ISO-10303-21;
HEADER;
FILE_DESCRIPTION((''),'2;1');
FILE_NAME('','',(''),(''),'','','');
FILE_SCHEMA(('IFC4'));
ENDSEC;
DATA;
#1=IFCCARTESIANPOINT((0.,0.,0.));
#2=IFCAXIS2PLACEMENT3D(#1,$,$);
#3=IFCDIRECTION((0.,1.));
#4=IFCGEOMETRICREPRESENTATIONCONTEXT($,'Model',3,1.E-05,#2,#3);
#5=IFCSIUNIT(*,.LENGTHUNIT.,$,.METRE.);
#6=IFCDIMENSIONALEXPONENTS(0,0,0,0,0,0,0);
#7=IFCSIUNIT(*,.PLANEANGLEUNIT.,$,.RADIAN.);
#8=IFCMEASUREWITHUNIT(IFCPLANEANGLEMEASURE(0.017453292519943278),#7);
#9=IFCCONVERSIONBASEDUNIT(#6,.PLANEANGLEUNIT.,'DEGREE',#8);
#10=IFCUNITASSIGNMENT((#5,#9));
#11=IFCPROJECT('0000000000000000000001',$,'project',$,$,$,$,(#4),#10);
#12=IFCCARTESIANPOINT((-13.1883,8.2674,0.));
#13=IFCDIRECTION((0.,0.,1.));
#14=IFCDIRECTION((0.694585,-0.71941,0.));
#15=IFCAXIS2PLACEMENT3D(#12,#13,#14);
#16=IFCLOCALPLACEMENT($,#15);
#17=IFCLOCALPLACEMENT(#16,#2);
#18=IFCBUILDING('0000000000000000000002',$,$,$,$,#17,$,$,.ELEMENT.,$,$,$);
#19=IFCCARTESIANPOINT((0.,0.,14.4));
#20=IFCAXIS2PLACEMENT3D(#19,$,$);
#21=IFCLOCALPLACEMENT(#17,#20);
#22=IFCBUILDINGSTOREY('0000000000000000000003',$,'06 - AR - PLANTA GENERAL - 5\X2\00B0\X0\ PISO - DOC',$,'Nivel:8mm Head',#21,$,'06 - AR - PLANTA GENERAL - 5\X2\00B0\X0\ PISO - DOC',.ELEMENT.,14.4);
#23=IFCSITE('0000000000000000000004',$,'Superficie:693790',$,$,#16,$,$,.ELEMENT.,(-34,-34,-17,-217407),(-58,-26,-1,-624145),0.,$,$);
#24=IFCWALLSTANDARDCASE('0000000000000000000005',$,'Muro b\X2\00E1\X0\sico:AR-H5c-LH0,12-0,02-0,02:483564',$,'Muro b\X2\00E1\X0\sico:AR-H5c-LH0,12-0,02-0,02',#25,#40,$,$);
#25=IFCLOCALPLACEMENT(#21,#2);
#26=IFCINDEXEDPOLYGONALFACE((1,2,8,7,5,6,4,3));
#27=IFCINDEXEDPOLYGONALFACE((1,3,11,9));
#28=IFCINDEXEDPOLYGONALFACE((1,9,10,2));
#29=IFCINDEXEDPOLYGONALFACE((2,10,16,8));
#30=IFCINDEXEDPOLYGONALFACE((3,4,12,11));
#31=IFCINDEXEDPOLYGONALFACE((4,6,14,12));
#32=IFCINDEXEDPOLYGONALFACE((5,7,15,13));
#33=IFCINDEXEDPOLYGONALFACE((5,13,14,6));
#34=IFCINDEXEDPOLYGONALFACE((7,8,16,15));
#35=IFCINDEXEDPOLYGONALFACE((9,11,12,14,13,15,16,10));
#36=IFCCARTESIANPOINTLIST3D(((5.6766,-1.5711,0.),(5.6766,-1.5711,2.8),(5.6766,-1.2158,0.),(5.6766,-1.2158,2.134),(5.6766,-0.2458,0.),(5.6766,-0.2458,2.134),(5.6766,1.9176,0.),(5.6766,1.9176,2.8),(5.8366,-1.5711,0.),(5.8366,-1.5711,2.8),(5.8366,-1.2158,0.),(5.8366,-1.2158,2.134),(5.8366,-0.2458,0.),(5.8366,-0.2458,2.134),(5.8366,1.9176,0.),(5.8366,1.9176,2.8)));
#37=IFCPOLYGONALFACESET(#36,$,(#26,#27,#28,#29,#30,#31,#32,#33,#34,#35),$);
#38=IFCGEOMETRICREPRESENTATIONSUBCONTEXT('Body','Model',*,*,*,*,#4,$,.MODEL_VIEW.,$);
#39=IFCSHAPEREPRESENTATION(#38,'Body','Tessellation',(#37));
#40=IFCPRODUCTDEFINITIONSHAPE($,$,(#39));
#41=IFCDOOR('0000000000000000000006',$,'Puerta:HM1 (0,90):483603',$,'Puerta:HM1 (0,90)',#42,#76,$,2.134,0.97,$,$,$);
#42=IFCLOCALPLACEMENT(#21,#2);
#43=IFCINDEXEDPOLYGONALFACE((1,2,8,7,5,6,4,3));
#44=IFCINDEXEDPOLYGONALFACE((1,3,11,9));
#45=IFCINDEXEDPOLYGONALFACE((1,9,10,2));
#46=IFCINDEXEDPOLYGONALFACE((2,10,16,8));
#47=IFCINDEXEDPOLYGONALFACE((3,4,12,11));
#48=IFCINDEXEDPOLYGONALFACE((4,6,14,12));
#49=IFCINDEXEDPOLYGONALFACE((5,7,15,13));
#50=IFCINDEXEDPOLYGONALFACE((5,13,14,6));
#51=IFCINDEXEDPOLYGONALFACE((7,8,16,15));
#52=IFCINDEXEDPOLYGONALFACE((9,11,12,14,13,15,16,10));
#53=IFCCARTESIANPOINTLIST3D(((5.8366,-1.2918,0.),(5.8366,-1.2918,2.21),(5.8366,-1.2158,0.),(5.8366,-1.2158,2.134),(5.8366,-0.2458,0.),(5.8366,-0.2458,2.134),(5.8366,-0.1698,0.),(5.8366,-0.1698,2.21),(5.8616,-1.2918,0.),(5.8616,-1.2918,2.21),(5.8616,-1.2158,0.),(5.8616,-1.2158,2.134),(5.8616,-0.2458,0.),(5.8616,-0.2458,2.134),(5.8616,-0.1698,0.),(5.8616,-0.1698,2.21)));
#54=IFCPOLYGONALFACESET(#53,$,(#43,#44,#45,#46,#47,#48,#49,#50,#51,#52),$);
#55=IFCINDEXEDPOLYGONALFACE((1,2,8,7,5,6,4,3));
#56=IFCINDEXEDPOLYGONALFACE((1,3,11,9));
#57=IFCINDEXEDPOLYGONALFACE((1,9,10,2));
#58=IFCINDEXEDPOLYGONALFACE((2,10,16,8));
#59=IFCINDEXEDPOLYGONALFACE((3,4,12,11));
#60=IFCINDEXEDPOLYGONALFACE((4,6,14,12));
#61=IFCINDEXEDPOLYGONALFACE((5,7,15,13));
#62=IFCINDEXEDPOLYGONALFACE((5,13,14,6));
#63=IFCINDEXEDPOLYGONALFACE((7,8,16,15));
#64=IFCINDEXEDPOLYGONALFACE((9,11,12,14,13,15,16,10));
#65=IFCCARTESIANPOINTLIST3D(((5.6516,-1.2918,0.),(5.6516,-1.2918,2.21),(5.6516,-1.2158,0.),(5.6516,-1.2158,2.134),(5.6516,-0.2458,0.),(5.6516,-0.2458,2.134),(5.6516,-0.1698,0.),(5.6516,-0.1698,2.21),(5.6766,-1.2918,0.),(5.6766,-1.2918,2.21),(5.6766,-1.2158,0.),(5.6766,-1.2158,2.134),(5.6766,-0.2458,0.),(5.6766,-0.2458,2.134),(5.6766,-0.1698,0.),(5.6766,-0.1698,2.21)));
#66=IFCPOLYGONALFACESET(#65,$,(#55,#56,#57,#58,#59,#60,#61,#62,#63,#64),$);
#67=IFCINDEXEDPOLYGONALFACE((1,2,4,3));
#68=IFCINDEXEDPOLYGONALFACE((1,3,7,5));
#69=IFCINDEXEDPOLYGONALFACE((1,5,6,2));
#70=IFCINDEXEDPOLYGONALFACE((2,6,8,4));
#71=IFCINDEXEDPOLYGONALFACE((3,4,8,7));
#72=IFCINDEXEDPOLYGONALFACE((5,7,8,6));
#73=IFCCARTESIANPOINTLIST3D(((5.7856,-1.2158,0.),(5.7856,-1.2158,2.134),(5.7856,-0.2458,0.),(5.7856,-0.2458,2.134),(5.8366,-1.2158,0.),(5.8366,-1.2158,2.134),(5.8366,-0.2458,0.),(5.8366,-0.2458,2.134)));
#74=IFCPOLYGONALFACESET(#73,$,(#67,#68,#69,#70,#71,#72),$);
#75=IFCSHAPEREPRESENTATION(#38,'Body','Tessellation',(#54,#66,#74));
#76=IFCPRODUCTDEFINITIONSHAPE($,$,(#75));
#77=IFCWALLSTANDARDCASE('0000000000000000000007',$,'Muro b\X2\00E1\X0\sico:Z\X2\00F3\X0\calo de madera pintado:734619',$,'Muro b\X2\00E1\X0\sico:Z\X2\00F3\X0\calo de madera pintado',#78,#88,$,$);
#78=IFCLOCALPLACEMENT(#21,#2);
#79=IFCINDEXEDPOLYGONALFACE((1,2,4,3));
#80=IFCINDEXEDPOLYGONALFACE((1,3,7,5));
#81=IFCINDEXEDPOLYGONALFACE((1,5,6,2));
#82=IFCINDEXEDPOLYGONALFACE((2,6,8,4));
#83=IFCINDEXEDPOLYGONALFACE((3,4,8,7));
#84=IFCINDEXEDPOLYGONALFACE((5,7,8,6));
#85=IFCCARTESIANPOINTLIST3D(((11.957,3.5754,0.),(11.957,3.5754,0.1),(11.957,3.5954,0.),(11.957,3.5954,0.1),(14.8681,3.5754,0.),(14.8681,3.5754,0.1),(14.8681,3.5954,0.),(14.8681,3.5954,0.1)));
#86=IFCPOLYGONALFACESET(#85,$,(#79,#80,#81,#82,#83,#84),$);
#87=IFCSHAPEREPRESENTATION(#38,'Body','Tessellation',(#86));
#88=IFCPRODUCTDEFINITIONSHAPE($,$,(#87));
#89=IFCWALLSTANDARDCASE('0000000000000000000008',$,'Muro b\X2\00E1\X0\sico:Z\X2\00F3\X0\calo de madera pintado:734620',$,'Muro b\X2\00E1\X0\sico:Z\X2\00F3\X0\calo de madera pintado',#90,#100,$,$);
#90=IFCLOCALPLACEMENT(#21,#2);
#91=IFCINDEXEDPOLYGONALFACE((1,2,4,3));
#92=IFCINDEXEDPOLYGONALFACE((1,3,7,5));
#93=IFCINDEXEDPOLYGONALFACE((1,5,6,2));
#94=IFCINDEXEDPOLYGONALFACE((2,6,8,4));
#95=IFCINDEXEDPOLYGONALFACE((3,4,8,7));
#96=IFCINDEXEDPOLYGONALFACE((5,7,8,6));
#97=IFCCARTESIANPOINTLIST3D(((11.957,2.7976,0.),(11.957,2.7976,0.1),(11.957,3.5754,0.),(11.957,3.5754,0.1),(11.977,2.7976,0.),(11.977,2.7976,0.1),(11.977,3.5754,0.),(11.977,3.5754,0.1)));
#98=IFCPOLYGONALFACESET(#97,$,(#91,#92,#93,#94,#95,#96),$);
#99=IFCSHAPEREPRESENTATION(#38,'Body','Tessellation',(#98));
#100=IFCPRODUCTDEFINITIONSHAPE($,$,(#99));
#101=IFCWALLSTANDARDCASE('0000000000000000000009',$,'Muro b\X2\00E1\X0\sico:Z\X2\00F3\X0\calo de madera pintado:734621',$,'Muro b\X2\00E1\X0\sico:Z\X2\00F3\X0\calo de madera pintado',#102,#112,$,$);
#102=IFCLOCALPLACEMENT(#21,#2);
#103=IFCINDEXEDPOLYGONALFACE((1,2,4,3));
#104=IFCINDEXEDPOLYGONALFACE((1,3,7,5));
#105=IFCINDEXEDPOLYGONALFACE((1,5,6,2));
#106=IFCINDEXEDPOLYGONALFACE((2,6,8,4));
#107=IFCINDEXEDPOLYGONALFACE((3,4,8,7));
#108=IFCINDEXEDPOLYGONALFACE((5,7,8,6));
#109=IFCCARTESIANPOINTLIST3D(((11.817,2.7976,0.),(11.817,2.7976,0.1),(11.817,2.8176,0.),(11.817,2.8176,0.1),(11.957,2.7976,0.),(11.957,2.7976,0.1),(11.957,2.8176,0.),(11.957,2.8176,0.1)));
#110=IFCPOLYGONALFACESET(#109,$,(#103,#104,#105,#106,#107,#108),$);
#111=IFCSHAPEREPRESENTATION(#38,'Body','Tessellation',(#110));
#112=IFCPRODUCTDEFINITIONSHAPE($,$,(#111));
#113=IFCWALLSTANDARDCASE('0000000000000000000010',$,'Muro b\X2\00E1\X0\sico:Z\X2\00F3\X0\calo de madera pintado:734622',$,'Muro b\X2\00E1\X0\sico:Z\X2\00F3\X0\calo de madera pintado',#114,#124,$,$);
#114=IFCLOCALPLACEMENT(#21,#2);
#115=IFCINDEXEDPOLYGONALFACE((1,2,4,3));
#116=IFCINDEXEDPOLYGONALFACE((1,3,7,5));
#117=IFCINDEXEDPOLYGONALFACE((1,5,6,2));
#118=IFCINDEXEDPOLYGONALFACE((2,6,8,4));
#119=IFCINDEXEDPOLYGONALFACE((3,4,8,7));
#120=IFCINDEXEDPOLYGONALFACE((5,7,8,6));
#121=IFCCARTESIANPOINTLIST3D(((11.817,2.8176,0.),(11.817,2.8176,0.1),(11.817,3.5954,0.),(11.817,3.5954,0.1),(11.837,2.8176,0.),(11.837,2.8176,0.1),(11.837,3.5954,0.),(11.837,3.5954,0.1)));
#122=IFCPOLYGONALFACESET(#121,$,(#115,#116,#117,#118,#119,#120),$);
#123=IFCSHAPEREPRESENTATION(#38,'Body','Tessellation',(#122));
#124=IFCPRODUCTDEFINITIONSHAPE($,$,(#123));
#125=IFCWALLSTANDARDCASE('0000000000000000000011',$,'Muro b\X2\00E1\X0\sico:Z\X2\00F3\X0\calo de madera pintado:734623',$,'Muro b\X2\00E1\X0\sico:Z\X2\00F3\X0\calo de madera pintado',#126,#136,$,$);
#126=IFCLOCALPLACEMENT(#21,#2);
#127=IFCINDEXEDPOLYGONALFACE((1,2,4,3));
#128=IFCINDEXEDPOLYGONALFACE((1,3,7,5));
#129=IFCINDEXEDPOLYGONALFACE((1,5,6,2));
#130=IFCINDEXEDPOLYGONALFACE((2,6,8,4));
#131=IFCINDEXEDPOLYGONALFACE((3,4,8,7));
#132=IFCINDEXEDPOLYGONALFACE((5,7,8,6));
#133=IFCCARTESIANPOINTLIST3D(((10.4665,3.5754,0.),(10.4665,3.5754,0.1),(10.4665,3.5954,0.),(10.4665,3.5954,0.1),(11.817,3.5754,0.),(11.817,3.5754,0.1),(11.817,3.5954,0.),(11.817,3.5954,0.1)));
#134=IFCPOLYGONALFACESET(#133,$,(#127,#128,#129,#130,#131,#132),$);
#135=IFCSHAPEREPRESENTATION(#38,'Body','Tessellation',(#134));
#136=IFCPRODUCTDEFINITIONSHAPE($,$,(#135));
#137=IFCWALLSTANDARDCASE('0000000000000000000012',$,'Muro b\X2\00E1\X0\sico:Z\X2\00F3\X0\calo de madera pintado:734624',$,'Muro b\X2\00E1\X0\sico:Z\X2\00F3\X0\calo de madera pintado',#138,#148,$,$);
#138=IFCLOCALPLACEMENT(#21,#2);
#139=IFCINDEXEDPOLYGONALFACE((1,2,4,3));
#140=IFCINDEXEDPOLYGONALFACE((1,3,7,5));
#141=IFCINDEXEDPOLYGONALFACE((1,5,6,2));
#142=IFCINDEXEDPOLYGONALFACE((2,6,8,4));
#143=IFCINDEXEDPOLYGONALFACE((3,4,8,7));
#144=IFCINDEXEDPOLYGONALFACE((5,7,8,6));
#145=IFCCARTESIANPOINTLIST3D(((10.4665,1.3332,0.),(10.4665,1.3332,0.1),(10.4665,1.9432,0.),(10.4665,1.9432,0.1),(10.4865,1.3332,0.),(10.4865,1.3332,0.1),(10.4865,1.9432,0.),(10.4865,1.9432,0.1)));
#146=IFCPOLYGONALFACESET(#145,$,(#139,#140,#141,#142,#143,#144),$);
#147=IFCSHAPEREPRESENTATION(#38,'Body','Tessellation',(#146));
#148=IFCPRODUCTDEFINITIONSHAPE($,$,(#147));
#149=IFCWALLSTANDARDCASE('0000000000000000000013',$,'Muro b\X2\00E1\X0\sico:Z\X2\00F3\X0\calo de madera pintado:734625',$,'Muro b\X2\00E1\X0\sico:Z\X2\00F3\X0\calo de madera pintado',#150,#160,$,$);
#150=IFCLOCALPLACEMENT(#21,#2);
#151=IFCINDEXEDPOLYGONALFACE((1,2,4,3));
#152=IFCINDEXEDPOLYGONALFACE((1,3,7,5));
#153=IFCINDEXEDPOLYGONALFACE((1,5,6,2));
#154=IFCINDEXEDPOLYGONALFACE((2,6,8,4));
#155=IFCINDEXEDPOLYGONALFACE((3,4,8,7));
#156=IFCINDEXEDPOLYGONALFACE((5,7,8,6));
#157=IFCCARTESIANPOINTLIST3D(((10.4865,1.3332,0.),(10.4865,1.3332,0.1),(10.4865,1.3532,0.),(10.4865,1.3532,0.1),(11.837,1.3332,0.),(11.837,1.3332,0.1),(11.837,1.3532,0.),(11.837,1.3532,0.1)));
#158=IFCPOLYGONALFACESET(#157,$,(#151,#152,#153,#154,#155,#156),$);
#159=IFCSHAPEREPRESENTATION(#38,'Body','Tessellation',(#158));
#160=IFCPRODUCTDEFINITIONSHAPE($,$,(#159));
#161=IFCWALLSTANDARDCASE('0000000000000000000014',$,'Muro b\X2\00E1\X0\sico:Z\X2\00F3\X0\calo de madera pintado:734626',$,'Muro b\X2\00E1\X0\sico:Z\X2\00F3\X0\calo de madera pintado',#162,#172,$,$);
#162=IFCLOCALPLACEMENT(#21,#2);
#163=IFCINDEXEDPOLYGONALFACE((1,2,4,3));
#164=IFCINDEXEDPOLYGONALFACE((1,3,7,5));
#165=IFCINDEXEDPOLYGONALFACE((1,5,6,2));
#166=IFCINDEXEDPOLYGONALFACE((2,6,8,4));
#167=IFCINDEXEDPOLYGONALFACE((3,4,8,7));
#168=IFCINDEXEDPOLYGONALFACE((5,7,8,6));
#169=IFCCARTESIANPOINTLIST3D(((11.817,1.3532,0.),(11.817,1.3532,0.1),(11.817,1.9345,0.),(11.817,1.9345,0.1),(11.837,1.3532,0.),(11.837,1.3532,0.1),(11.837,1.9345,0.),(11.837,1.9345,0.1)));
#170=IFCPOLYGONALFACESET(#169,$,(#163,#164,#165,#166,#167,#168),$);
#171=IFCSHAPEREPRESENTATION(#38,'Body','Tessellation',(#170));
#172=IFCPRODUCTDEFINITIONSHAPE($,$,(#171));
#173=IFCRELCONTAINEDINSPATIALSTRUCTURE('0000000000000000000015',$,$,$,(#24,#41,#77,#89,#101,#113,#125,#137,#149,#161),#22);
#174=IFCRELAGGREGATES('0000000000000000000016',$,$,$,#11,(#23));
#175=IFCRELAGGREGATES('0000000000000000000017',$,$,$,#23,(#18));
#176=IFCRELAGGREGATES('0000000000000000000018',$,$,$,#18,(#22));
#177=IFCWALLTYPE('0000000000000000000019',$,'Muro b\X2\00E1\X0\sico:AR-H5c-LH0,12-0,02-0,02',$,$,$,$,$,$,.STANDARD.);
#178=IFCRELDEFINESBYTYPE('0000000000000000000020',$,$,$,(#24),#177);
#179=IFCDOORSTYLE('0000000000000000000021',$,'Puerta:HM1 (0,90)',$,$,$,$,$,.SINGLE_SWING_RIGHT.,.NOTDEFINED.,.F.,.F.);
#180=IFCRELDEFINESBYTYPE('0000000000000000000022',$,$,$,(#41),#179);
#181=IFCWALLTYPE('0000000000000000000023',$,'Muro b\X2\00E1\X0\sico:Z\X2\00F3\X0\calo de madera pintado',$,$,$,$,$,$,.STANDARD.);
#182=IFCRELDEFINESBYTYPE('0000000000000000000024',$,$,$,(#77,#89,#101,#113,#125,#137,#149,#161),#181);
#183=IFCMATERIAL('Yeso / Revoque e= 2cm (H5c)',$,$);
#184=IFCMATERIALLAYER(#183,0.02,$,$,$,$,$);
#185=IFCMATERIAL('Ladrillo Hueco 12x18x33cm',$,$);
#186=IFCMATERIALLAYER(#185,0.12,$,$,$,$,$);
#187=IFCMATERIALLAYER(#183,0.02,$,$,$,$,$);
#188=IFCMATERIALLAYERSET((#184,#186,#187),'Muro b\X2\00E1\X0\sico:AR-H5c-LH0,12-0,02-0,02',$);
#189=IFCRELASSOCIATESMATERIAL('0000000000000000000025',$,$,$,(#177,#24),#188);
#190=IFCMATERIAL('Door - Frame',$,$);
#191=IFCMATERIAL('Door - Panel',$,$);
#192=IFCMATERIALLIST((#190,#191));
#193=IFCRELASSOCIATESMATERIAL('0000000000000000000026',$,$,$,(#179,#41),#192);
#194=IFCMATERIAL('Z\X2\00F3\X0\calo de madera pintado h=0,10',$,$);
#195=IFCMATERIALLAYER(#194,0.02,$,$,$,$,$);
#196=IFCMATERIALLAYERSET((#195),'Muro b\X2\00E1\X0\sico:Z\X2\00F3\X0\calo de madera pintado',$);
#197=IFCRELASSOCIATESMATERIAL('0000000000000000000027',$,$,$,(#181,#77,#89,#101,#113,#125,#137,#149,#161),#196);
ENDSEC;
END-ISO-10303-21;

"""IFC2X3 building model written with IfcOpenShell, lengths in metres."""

from ifc_helpers import new_model, entity, si_unit, converted_unit, direction, frame, frame_2d, origin, place, context, subcontext, project, spatial, polyline, rectangle, outline, extrude, source, transform, mapped, material, material_list, layer, layer_set, layer_usage, type_object, type_shapes, element, fill, save


model = new_model("IFC2X3")

# Units and contexts
model_context = context("Model", 3, precision=1e-05, world=origin(), true_north=direction((0.0, 1.0)))
body_context = subcontext(model_context, "Body", "Model", "MODEL_VIEW")
ifc_project = project(units=[si_unit("LENGTHUNIT", "METRE"), converted_unit("PLANEANGLEUNIT", "DEGREE", entity("IfcPlaneAngleMeasure", 0.017453292519943278), si_unit("PLANEANGLEUNIT", "RADIAN"), dimensions=[0, 0, 0, 0, 0, 0, 0])], contexts=[model_context])

# Site, building, storey
site_placement = place(None, frame((-13.1883, 8.2674, 0.0), z_axis=(0.0, 0.0, 1.0), x_axis=(0.694585, -0.71941, 0.0)))
site = spatial("IfcSite", under=ifc_project, at=site_placement, Name="Superficie:693790", CompositionType="ELEMENT", RefLatitude=(-34, -34, -17, -217407), RefLongitude=(-58, -26, -1, -624145), RefElevation=0.0)
building_placement = place(site_placement, origin())
building = spatial("IfcBuilding", under=site, at=building_placement, CompositionType="ELEMENT")
storey_placement = place(building_placement, frame((0.0, 0.0, 14.4)))
storey = spatial("IfcBuildingStorey", under=building, at=storey_placement, Name="06 - AR - PLANTA GENERAL - 5° PISO - DOC", ObjectType="Nivel:8mm Head", LongName="06 - AR - PLANTA GENERAL - 5° PISO - DOC", CompositionType="ELEMENT", Elevation=14.4)

# Shared definitions
ifc_material_1 = material(Name="Door - Frame")
ifc_material_2 = material(Name="Door - Panel")
ifc_material_list = material_list([ifc_material_1, ifc_material_2])

# Wall, opening, door
ifc_material_3 = material(Name="Yeso / Revoque e= 2cm (H5c)")
ifc_layer_1 = layer(ifc_material_3, 0.02)
ifc_material_4 = material(Name="Ladrillo Hueco 12x18x33cm")
ifc_layer_2 = layer(ifc_material_4, 0.12)
ifc_layer_3 = layer(ifc_material_3, 0.02)
ifc_layer_set_1 = layer_set([ifc_layer_1, ifc_layer_2, ifc_layer_3], Name="Muro básico:AR-H5c-LH0,12-0,02-0,02")
ifc_layer_usage_1 = layer_usage(ifc_layer_set_1, "AXIS2", "NEGATIVE", 0.08)
wall_type_1 = type_object("IfcWallType", Name="Muro básico:AR-H5c-LH0,12-0,02-0,02", PredefinedType="STANDARD", material=ifc_layer_set_1)
wall_1_placement = place(storey_placement, frame((5.7566, 1.9176, 0.0), z_axis=(0.0, 0.0, 1.0), x_axis=(0.0, -1.0, 0.0)))
wall_1 = element("IfcWallStandardCase", 1, at=wall_1_placement, inside=storey, type_object=wall_type_1, material=ifc_layer_usage_1, Name="Muro básico:AR-H5c-LH0,12-0,02-0,02:483564", ObjectType="Muro básico:AR-H5c-LH0,12-0,02-0,02", context=body_context, shape_type="SweptSolid", body=[
    extrude(rectangle(XDim=3.4887, YDim=0.16, at=frame_2d((1.7443, 0.0), x_axis=(-1.0, 0.0))), origin(), (0.0, 0.0, 1.0), 2.8),
])
opening_1_placement = place(wall_1_placement, frame((2.1634, -0.08, 0.0)))
opening_1 = element("IfcOpeningElement", 2, at=opening_1_placement, cuts=wall_1, ObjectType="Opening", context=body_context, shape_type="SweptSolid", body=[
    extrude(rectangle(XDim=0.97, YDim=2.134, at=frame_2d((1.067, 0.485), x_axis=(0.0, 1.0))), frame((0.0, 0.0, 0.0), z_axis=(0.0, 1.0, 0.0), x_axis=(0.0, 0.0, 1.0)), (0.0, 0.0, 1.0), 0.16),
])
door_style_1 = type_object("IfcDoorStyle", Name="Puerta:HM1 (0,90)", ConstructionType="NOTDEFINED", OperationType="SINGLE_SWING_RIGHT", ParameterTakesPrecedence=False, Sizeable=False, material=ifc_material_list)
shared_shape_1 = source(origin(), body_context, "Body", "SweptSolid", [
    extrude(outline(polyline([(-0.561, -1.124), (0.561, -1.124), (0.561, 1.086), (0.485, 1.086), (0.485, -1.048), (-0.485, -1.048), (-0.485, 1.086), (-0.561, 1.086), (-0.561, -1.124)])), frame((0.485, 0.16, 1.086), z_axis=(0.0, 1.0, 0.0), x_axis=(1.0, 0.0, 0.0)), (0.0, 0.0, 1.0), 0.025),
    extrude(outline(polyline([(-1.124, -0.561), (1.086, -0.561), (1.086, -0.485), (-1.048, -0.485), (-1.048, 0.485), (1.086, 0.485), (1.086, 0.561), (-1.124, 0.561), (-1.124, -0.561)])), frame((0.485, -0.025, 1.086), z_axis=(0.0, 1.0, 0.0), x_axis=(0.0, 0.0, -1.0)), (0.0, 0.0, 1.0), 0.025),
    extrude(rectangle(XDim=0.051, YDim=0.97, at=frame_2d((0.0, 0.0), x_axis=(1.0, 0.0))), frame((0.485, 0.1345, 0.0), z_axis=(0.0, 0.0, 1.0), x_axis=(0.0, 1.0, 0.0)), (0.0, 0.0, 1.0), 2.134),
])
type_shapes(door_style_1, [shared_shape_1])
door_1_placement = place(opening_1_placement, origin())
door_1 = element("IfcDoor", 3, at=door_1_placement, inside=storey, type_object=door_style_1, material=ifc_material_list, Name="Puerta:HM1 (0,90):483603", ObjectType="Puerta:HM1 (0,90)", OverallHeight=2.134, OverallWidth=0.97, context=body_context, shape_type="MappedRepresentation", body=[
    mapped(shared_shape_1, transform((0.0, 0.0, 0.0), scale=1.0)),
])
fill(opening_1, door_1)

# Walls
ifc_material_5 = material(Name="Zócalo de madera pintado h=0,10")
ifc_layer_4 = layer(ifc_material_5, 0.02)
ifc_layer_set_2 = layer_set([ifc_layer_4], Name="Muro básico:Zócalo de madera pintado")
ifc_layer_usage_2 = layer_usage(ifc_layer_set_2, "AXIS2", "NEGATIVE", 0.01)
wall_type_2 = type_object("IfcWallType", Name="Muro básico:Zócalo de madera pintado", PredefinedType="STANDARD", material=ifc_layer_set_2)
wall_2_placement = place(storey_placement, frame((11.957, 3.5854, 0.0)))
element("IfcWallStandardCase", 4, at=wall_2_placement, inside=storey, type_object=wall_type_2, material=ifc_layer_usage_2, Name="Muro básico:Zócalo de madera pintado:734619", ObjectType="Muro básico:Zócalo de madera pintado", context=body_context, shape_type="SweptSolid", body=[
    extrude(rectangle(XDim=2.911, YDim=0.02, at=frame_2d((1.4555, 0.0), x_axis=(-1.0, 0.0))), origin(), (0.0, 0.0, 1.0), 0.1),
])
ifc_layer_usage_3 = layer_usage(ifc_layer_set_2, "AXIS2", "NEGATIVE", 0.01)
wall_3_placement = place(storey_placement, frame((11.967, 2.7976, 0.0), z_axis=(0.0, 0.0, 1.0), x_axis=(0.0, 1.0, 0.0)))
element("IfcWallStandardCase", 5, at=wall_3_placement, inside=storey, type_object=wall_type_2, material=ifc_layer_usage_3, Name="Muro básico:Zócalo de madera pintado:734620", ObjectType="Muro básico:Zócalo de madera pintado", context=body_context, shape_type="SweptSolid", body=[
    extrude(rectangle(XDim=0.7779, YDim=0.02, at=frame_2d((0.3889, 0.0), x_axis=(-1.0, 0.0))), origin(), (0.0, 0.0, 1.0), 0.1),
])
ifc_layer_usage_4 = layer_usage(ifc_layer_set_2, "AXIS2", "NEGATIVE", 0.01)
wall_4_placement = place(storey_placement, frame((11.817, 2.8076, 0.0)))
element("IfcWallStandardCase", 6, at=wall_4_placement, inside=storey, type_object=wall_type_2, material=ifc_layer_usage_4, Name="Muro básico:Zócalo de madera pintado:734621", ObjectType="Muro básico:Zócalo de madera pintado", context=body_context, shape_type="SweptSolid", body=[
    extrude(rectangle(XDim=0.14, YDim=0.02, at=frame_2d((0.07, 0.0), x_axis=(-1.0, 0.0))), origin(), (0.0, 0.0, 1.0), 0.1),
])
ifc_layer_usage_5 = layer_usage(ifc_layer_set_2, "AXIS2", "NEGATIVE", 0.01)
wall_5_placement = place(storey_placement, frame((11.827, 3.5954, 0.0), z_axis=(0.0, 0.0, 1.0), x_axis=(0.0, -1.0, 0.0)))
element("IfcWallStandardCase", 7, at=wall_5_placement, inside=storey, type_object=wall_type_2, material=ifc_layer_usage_5, Name="Muro básico:Zócalo de madera pintado:734622", ObjectType="Muro básico:Zócalo de madera pintado", context=body_context, shape_type="SweptSolid", body=[
    extrude(rectangle(XDim=0.7779, YDim=0.02, at=frame_2d((0.3889, 0.0), x_axis=(-1.0, 0.0))), origin(), (0.0, 0.0, 1.0), 0.1),
])
ifc_layer_usage_6 = layer_usage(ifc_layer_set_2, "AXIS2", "NEGATIVE", 0.01)
wall_6_placement = place(storey_placement, frame((10.4665, 3.5854, 0.0)))
element("IfcWallStandardCase", 8, at=wall_6_placement, inside=storey, type_object=wall_type_2, material=ifc_layer_usage_6, Name="Muro básico:Zócalo de madera pintado:734623", ObjectType="Muro básico:Zócalo de madera pintado", context=body_context, shape_type="SweptSolid", body=[
    extrude(rectangle(XDim=1.3505, YDim=0.02, at=frame_2d((0.6753, 0.0), x_axis=(-1.0, 0.0))), origin(), (0.0, 0.0, 1.0), 0.1),
])
ifc_layer_usage_7 = layer_usage(ifc_layer_set_2, "AXIS2", "NEGATIVE", 0.01)
wall_7_placement = place(storey_placement, frame((10.4765, 1.3332, 0.0), z_axis=(0.0, 0.0, 1.0), x_axis=(0.0, 1.0, 0.0)))
element("IfcWallStandardCase", 9, at=wall_7_placement, inside=storey, type_object=wall_type_2, material=ifc_layer_usage_7, Name="Muro básico:Zócalo de madera pintado:734624", ObjectType="Muro básico:Zócalo de madera pintado", context=body_context, shape_type="SweptSolid", body=[
    extrude(rectangle(XDim=0.61, YDim=0.02, at=frame_2d((0.305, 0.0), x_axis=(-1.0, 0.0))), origin(), (0.0, 0.0, 1.0), 0.1),
])
ifc_layer_usage_8 = layer_usage(ifc_layer_set_2, "AXIS2", "NEGATIVE", 0.01)
wall_8_placement = place(storey_placement, frame((11.837, 1.3432, 0.0), z_axis=(0.0, 0.0, 1.0), x_axis=(-1.0, 0.0, 0.0)))
element("IfcWallStandardCase", 10, at=wall_8_placement, inside=storey, type_object=wall_type_2, material=ifc_layer_usage_8, Name="Muro básico:Zócalo de madera pintado:734625", ObjectType="Muro básico:Zócalo de madera pintado", context=body_context, shape_type="SweptSolid", body=[
    extrude(rectangle(XDim=1.3505, YDim=0.02, at=frame_2d((0.6753, 0.0), x_axis=(-1.0, 0.0))), origin(), (0.0, 0.0, 1.0), 0.1),
])
ifc_layer_usage_9 = layer_usage(ifc_layer_set_2, "AXIS2", "NEGATIVE", 0.01)
wall_9_placement = place(storey_placement, frame((11.827, 1.9345, 0.0), z_axis=(0.0, 0.0, 1.0), x_axis=(0.0, -1.0, 0.0)))
element("IfcWallStandardCase", 11, at=wall_9_placement, inside=storey, type_object=wall_type_2, material=ifc_layer_usage_9, Name="Muro básico:Zócalo de madera pintado:734626", ObjectType="Muro básico:Zócalo de madera pintado", context=body_context, shape_type="SweptSolid", body=[
    extrude(rectangle(XDim=0.5814, YDim=0.02, at=frame_2d((0.2907, 0.0), x_axis=(-1.0, 0.0))), origin(), (0.0, 0.0, 1.0), 0.1),
])

save(model, "model.ifc")
